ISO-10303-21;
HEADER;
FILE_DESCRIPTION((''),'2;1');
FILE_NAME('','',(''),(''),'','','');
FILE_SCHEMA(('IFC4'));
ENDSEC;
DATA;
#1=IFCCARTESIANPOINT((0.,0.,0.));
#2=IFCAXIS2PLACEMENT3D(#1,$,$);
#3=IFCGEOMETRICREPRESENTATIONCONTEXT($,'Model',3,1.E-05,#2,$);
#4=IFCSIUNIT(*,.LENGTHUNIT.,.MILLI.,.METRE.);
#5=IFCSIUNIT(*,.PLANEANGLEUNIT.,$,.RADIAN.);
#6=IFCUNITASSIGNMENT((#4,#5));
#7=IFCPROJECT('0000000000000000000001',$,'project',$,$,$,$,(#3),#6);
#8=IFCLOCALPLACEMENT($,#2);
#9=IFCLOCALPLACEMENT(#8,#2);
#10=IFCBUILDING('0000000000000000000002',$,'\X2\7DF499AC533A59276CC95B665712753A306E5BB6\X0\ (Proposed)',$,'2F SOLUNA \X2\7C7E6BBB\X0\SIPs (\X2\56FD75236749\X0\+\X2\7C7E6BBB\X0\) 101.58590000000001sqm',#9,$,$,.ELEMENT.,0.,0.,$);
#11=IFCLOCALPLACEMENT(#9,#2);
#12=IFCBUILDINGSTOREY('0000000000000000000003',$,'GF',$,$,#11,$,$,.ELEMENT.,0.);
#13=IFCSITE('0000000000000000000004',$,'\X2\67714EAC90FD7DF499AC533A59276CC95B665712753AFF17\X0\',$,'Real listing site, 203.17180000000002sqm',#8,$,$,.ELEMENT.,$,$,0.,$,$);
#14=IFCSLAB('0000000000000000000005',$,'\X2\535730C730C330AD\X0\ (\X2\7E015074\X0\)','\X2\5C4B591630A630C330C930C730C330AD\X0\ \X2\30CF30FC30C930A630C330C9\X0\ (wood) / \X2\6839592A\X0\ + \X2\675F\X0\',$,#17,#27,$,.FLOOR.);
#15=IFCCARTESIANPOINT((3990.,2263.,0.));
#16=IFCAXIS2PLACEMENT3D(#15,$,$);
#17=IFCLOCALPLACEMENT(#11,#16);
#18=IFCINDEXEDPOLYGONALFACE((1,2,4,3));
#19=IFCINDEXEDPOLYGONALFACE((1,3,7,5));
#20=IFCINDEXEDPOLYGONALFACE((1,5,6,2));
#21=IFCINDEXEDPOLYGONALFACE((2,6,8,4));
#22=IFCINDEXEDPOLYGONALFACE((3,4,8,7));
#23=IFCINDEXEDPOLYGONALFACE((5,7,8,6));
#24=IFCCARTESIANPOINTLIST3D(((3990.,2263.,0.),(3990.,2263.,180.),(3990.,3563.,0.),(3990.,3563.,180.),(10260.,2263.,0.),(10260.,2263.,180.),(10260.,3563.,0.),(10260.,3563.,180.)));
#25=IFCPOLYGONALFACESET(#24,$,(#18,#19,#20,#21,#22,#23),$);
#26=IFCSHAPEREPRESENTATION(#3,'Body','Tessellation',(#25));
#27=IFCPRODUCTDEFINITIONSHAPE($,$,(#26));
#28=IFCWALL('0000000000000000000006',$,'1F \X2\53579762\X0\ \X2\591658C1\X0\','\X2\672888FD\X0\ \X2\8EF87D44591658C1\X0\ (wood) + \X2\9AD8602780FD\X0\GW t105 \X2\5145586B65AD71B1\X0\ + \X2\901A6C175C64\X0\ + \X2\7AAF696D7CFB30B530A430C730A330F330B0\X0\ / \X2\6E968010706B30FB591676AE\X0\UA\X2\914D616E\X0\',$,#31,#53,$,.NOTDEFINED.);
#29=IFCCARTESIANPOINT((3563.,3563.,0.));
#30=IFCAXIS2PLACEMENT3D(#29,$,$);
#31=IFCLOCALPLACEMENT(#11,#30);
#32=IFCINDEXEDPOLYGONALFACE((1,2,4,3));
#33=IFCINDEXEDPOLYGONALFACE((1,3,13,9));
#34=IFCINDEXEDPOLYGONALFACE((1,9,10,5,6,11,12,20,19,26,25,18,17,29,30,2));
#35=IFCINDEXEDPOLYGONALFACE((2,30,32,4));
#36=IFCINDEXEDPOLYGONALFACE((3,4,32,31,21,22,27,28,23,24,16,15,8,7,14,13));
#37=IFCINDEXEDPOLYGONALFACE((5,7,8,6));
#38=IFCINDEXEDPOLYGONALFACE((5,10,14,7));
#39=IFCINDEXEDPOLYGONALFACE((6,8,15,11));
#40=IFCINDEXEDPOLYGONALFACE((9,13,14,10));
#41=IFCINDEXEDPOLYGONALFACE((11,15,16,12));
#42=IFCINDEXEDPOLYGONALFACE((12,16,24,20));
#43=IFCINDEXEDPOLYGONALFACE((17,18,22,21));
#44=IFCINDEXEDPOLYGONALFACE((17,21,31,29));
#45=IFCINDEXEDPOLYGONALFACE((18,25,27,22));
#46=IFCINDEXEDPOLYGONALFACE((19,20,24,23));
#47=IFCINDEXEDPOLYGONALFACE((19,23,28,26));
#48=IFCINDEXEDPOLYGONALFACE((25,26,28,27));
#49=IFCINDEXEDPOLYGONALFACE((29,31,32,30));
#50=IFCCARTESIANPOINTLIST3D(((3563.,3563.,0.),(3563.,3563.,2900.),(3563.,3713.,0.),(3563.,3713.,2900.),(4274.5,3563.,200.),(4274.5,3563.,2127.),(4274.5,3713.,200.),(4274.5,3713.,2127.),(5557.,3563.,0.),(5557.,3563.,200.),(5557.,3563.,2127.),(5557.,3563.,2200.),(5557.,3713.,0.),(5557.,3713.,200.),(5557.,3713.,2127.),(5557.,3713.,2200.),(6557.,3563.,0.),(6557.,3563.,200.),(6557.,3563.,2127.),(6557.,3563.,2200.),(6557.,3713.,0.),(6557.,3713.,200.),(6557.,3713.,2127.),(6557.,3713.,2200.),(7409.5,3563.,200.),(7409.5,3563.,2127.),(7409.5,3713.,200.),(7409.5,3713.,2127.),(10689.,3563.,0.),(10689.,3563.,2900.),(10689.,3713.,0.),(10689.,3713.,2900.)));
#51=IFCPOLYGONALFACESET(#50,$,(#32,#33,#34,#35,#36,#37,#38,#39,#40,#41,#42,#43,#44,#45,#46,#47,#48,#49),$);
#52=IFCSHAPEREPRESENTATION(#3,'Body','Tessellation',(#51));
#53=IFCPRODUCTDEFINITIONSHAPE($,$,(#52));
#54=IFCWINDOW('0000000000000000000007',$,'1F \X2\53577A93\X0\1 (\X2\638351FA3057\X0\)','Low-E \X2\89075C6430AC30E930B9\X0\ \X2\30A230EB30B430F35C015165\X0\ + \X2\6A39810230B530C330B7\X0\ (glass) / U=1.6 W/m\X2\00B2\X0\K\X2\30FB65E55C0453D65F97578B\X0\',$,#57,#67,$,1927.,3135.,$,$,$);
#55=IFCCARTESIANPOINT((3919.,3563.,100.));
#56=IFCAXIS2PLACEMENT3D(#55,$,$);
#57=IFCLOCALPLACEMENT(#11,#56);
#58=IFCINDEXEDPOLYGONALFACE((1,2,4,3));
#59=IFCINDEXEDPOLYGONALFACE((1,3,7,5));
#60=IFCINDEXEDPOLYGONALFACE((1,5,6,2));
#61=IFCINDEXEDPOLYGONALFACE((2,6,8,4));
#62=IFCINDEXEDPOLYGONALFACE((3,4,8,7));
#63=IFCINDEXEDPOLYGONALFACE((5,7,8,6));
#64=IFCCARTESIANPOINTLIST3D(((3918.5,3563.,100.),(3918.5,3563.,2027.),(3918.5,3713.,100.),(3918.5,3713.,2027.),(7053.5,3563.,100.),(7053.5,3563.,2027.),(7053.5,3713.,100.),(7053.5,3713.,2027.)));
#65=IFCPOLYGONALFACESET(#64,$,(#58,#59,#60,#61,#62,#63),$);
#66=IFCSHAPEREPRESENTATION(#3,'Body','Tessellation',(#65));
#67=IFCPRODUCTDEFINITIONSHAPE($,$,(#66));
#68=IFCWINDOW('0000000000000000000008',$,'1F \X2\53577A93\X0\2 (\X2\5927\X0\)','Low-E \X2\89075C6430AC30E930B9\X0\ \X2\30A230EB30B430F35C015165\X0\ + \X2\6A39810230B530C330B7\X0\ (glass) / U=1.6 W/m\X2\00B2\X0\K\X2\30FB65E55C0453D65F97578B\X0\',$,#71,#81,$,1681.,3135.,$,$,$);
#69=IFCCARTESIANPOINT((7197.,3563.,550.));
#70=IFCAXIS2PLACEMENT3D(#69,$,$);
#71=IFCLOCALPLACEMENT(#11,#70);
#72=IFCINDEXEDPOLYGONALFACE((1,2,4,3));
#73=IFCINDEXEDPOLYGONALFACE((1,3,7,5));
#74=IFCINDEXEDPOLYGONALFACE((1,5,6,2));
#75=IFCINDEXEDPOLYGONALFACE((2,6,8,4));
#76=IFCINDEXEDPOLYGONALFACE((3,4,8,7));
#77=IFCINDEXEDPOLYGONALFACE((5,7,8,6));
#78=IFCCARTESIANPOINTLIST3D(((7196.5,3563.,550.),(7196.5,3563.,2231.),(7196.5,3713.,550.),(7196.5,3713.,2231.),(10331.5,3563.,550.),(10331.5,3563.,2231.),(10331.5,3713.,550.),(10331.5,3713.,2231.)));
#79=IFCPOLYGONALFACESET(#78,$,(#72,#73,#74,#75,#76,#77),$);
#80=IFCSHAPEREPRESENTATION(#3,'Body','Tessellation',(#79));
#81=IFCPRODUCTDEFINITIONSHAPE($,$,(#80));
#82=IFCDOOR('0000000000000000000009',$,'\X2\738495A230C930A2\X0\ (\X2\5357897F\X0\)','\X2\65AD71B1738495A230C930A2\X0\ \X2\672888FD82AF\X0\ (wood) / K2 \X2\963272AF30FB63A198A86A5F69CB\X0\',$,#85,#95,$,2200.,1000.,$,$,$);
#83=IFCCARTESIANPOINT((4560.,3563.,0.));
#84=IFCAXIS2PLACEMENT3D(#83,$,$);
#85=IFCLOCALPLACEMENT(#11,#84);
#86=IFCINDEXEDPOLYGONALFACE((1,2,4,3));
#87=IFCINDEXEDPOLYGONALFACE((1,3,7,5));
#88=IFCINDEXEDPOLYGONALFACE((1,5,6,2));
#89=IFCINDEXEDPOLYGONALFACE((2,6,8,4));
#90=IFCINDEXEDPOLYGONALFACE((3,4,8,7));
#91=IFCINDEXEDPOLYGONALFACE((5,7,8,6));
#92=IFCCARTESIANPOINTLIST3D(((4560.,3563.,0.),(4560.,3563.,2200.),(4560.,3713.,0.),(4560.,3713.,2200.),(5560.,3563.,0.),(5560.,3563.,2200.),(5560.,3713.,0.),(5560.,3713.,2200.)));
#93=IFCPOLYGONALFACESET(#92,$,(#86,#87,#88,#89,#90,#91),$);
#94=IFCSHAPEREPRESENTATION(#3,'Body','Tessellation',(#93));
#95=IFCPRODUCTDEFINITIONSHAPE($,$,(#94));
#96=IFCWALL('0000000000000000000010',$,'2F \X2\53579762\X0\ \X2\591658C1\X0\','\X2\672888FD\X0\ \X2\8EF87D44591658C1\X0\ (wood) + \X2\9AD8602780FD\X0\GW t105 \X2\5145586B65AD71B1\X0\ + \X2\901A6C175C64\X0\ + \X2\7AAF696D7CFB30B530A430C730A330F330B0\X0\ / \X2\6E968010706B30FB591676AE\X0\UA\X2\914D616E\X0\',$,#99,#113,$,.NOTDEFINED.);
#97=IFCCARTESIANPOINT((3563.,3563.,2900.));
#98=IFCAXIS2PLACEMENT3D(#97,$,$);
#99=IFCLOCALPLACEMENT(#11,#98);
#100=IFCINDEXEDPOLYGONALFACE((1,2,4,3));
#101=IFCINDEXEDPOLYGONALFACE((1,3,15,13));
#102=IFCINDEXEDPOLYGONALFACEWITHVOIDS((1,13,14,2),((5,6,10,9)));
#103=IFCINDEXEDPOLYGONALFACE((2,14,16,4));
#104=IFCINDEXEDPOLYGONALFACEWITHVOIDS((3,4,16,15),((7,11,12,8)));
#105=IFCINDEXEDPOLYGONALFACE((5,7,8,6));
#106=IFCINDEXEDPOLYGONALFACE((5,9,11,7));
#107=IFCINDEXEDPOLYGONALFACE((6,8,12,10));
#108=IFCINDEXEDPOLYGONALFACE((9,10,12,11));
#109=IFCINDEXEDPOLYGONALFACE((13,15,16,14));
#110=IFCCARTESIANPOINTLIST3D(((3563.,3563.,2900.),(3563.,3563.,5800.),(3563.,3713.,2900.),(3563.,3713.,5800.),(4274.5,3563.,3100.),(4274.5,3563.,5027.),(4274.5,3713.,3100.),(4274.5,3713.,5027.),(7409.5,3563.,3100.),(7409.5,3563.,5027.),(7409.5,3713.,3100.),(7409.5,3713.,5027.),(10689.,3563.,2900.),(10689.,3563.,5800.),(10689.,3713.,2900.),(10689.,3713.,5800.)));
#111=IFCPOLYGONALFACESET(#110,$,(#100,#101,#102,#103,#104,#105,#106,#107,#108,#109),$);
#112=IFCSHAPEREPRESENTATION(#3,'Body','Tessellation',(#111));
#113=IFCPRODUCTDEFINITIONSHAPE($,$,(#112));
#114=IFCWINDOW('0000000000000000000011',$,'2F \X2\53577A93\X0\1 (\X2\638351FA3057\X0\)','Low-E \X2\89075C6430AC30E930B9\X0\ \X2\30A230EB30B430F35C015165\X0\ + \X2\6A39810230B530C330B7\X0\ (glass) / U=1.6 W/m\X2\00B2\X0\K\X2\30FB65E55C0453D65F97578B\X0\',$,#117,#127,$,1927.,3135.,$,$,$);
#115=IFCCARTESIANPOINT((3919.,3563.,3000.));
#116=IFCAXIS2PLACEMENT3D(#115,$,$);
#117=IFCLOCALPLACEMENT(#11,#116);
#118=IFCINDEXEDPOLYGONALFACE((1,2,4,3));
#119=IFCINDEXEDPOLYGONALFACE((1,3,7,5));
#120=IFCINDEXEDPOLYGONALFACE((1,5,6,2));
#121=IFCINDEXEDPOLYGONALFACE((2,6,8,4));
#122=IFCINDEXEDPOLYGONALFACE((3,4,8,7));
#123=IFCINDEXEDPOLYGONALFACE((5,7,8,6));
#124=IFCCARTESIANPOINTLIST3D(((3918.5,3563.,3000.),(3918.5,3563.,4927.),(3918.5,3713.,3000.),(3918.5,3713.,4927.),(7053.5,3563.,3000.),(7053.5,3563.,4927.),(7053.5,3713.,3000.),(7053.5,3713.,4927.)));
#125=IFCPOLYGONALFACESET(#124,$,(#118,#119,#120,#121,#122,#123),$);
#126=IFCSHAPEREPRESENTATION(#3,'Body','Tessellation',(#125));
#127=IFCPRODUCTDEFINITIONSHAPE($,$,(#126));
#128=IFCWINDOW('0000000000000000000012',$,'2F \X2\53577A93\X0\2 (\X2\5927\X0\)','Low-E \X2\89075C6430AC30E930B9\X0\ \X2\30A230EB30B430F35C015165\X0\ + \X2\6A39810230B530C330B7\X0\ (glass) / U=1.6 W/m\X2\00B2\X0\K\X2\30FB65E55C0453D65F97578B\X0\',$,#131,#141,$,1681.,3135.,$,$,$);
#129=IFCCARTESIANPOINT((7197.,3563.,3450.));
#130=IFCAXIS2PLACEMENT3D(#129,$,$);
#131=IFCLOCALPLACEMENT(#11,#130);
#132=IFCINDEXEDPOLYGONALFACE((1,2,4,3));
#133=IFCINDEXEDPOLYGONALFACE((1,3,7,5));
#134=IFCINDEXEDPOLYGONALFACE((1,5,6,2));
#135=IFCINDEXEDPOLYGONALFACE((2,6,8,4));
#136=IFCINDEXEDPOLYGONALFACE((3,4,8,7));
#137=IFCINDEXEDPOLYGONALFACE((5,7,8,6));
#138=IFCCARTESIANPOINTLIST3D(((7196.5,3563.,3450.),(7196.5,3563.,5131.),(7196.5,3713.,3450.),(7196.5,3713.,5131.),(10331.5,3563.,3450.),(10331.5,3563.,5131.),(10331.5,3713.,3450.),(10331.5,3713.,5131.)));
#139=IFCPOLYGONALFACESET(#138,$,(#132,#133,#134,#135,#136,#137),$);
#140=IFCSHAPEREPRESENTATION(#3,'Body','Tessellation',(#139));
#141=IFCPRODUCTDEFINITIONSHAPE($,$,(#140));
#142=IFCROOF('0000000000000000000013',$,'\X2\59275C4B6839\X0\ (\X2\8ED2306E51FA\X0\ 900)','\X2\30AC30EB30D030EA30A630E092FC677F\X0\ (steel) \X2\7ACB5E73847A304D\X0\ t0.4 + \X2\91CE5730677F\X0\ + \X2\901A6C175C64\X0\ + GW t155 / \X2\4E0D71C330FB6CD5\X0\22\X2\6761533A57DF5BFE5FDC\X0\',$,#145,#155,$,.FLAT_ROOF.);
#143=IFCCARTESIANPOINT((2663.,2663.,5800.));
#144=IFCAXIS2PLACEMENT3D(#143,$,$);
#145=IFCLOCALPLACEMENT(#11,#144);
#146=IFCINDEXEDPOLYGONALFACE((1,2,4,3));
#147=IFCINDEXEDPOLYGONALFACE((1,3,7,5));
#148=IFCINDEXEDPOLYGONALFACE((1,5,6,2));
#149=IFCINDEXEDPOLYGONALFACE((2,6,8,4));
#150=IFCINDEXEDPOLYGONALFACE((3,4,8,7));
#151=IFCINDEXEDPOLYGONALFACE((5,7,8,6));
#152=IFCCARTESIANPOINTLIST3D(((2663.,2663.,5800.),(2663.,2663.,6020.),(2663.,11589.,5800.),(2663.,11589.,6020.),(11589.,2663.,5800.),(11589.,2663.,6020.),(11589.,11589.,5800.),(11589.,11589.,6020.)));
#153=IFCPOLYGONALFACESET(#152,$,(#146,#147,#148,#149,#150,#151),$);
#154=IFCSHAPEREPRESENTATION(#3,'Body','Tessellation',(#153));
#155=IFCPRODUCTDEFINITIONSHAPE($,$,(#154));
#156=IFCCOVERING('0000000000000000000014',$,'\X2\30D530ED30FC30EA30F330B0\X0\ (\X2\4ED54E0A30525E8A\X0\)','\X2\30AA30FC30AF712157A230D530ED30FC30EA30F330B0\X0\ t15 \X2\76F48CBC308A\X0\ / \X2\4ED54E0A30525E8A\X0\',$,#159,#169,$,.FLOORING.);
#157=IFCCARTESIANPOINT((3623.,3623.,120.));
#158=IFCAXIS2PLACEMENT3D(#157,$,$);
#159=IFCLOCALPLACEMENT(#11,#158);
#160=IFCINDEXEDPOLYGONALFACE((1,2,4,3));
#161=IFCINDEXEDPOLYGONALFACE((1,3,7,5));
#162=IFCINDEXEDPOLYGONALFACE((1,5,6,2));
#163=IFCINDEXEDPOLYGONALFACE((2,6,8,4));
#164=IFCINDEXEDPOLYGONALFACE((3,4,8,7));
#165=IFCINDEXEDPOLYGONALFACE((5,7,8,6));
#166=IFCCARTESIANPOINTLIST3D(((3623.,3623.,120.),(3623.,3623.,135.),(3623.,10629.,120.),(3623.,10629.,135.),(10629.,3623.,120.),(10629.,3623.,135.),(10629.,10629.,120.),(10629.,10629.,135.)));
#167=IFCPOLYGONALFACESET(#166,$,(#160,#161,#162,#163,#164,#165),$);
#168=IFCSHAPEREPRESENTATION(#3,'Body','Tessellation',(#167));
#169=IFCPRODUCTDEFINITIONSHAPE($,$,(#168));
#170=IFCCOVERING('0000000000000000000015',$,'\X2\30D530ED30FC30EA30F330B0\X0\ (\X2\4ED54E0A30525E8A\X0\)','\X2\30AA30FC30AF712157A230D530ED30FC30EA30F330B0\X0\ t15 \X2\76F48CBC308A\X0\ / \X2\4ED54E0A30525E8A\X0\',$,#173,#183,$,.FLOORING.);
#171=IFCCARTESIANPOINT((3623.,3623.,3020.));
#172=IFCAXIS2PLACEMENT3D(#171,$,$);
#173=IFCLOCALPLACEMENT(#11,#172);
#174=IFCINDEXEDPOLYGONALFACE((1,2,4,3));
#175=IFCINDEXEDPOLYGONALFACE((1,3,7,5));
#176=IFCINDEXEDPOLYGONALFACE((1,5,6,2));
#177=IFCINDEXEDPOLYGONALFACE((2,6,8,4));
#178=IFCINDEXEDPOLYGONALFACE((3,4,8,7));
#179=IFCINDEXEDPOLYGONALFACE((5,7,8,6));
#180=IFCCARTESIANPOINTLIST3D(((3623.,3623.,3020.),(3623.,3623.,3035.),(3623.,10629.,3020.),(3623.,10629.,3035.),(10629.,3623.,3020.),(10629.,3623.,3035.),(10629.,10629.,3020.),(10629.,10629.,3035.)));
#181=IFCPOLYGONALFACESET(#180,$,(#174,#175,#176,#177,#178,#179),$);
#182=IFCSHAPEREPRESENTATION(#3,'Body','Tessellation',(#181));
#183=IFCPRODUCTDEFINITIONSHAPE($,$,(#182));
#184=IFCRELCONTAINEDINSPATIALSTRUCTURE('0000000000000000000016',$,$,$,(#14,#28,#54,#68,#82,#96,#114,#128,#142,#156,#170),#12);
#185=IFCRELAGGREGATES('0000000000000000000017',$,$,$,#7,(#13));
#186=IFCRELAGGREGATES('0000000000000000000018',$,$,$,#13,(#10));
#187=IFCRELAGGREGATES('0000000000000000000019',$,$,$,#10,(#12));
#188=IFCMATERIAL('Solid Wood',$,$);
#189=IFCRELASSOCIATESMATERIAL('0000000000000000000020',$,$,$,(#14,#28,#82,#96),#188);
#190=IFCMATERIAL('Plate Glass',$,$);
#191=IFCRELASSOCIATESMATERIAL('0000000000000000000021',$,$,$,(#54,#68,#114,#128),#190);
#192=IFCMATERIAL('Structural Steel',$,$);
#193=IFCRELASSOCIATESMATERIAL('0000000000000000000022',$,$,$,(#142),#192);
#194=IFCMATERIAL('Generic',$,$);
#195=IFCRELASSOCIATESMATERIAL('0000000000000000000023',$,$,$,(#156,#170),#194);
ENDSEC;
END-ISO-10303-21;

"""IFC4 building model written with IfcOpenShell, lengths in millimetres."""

from ifc_helpers import new_model, si_unit, frame, frame_2d, origin, place, context, project, spatial, rectangle, extrude, material, element, fill, save


model = new_model("IFC4")

# Units and contexts
model_context = context("Model", 3, precision=1e-05, world=origin())
ifc_project = project(units=[si_unit("LENGTHUNIT", "METRE", prefix="MILLI"), si_unit("PLANEANGLEUNIT", "RADIAN")], contexts=[model_context])

# Site, building, storey
site_placement = place(None, origin())
site = spatial("IfcSite", under=ifc_project, at=site_placement, Name="東京都練馬区大泉学園町７", ObjectType="Real listing site, 203.17180000000002sqm", CompositionType="ELEMENT", RefElevation=0.0)
building_placement = place(site_placement, origin())
building = spatial("IfcBuilding", under=site, at=building_placement, Name="練馬区大泉学園町の家 (Proposed)", ObjectType="2F SOLUNA 籾殻SIPs (国産杉+籾殻) 101.58590000000001sqm", CompositionType="ELEMENT", ElevationOfRefHeight=0.0, ElevationOfTerrain=0.0)
storey_placement = place(building_placement, origin())
storey = spatial("IfcBuildingStorey", under=building, at=storey_placement, Name="GF", CompositionType="ELEMENT", Elevation=0.0)

# Slab
ifc_material_1 = material(Name="Solid Wood")
slab_1_placement = place(storey_placement, frame((3990.0, 2263.0, 0.0)))
element("IfcSlab", 1, at=slab_1_placement, inside=storey, material=ifc_material_1, Name="南デッキ (縁側)", Description="屋外ウッドデッキ ハードウッド (wood) / 根太 + 束", PredefinedType="FLOOR", context=model_context, shape_type="SweptSolid", body=[
    extrude(rectangle(XDim=6270.0, YDim=1300.0, at=frame_2d((3135.0, 650.0))), frame((3990.0, 2263.0, 0.0)), (0.0, 0.0, 1.0), 180.0),
])

# Wall, openings, windows, door
wall_1_placement = place(storey_placement, frame((3563.0, 3563.0, 0.0)))
wall_1 = element("IfcWall", 2, at=wall_1_placement, inside=storey, material=ifc_material_1, Name="1F 南面 外壁", Description="木製 軸組外壁 (wood) + 高性能GW t105 充填断熱 + 通気層 + 窯業系サイディング / 準耐火・外皮UA配慮", PredefinedType="NOTDEFINED", context=model_context, shape_type="SweptSolid", body=[
    extrude(rectangle(XDim=7126.0, YDim=150.0, at=frame_2d((3563.0, 75.0))), frame((3563.0, 3563.0, 0.0)), (0.0, 0.0, 1.0), 2900.0),
])
opening_1_placement = place(storey_placement, frame((3919.0, 3563.0, 100.0)))
opening_1 = element("IfcOpeningElement", 3, at=opening_1_placement, cuts=wall_1, PredefinedType="NOTDEFINED", context=model_context, shape_type="SweptSolid", body=[
    extrude(rectangle(XDim=3135.0, YDim=150.0, at=frame_2d((1567.0, 75.0))), frame((3919.0, 3563.0, 100.0)), (0.0, 0.0, 1.0), 1927.0),
])
opening_2_placement = place(storey_placement, frame((7197.0, 3563.0, 550.0)))
opening_2 = element("IfcOpeningElement", 4, at=opening_2_placement, cuts=wall_1, PredefinedType="NOTDEFINED", context=model_context, shape_type="SweptSolid", body=[
    extrude(rectangle(XDim=3135.0, YDim=150.0, at=frame_2d((1567.0, 75.0))), frame((7197.0, 3563.0, 550.0)), (0.0, 0.0, 1.0), 1681.0),
])
opening_3_placement = place(storey_placement, frame((4560.0, 3563.0, 0.0)))
opening_3 = element("IfcOpeningElement", 5, at=opening_3_placement, cuts=wall_1, PredefinedType="NOTDEFINED", context=model_context, shape_type="SweptSolid", body=[
    extrude(rectangle(XDim=1000.0, YDim=150.0, at=frame_2d((500.0, 75.0))), frame((4560.0, 3563.0, 0.0)), (0.0, 0.0, 1.0), 2200.0),
])
ifc_material_2 = material(Name="Plate Glass")
window_1_placement = place(storey_placement, frame((3919.0, 3563.0, 100.0)))
window_1 = element("IfcWindow", 6, at=window_1_placement, inside=storey, material=ifc_material_2, Name="1F 南窓1 (掃出し)", Description="Low-E 複層ガラス アルゴン封入 + 樹脂サッシ (glass) / U=1.6 W/m²K・日射取得型", OverallHeight=1927.0, OverallWidth=3135.0, context=model_context, shape_type="SweptSolid", body=[
    extrude(rectangle(XDim=3135.0, YDim=150.0, at=frame_2d((1567.0, 75.0))), frame((3919.0, 3563.0, 100.0)), (0.0, 0.0, 1.0), 1927.0),
])
fill(opening_1, window_1)
window_2_placement = place(storey_placement, frame((7197.0, 3563.0, 550.0)))
window_2 = element("IfcWindow", 7, at=window_2_placement, inside=storey, material=ifc_material_2, Name="1F 南窓2 (大)", Description="Low-E 複層ガラス アルゴン封入 + 樹脂サッシ (glass) / U=1.6 W/m²K・日射取得型", OverallHeight=1681.0, OverallWidth=3135.0, context=model_context, shape_type="SweptSolid", body=[
    extrude(rectangle(XDim=3135.0, YDim=150.0, at=frame_2d((1567.0, 75.0))), frame((7197.0, 3563.0, 550.0)), (0.0, 0.0, 1.0), 1681.0),
])
fill(opening_2, window_2)
door_placement = place(storey_placement, frame((4560.0, 3563.0, 0.0)))
door = element("IfcDoor", 8, at=door_placement, inside=storey, material=ifc_material_1, Name="玄関ドア (南西)", Description="断熱玄関ドア 木製芯 (wood) / K2 防犯・採風機構", OverallHeight=2200.0, OverallWidth=1000.0, context=model_context, shape_type="SweptSolid", body=[
    extrude(rectangle(XDim=1000.0, YDim=150.0, at=frame_2d((500.0, 75.0))), frame((4560.0, 3563.0, 0.0)), (0.0, 0.0, 1.0), 2200.0),
])
fill(opening_3, door)

# Wall, openings, windows
wall_2_placement = place(storey_placement, frame((3563.0, 3563.0, 2900.0)))
wall_2 = element("IfcWall", 9, at=wall_2_placement, inside=storey, material=ifc_material_1, Name="2F 南面 外壁", Description="木製 軸組外壁 (wood) + 高性能GW t105 充填断熱 + 通気層 + 窯業系サイディング / 準耐火・外皮UA配慮", PredefinedType="NOTDEFINED", context=model_context, shape_type="SweptSolid", body=[
    extrude(rectangle(XDim=7126.0, YDim=150.0, at=frame_2d((3563.0, 75.0))), frame((3563.0, 3563.0, 2900.0)), (0.0, 0.0, 1.0), 2900.0),
])
opening_4_placement = place(storey_placement, frame((3919.0, 3563.0, 3000.0)))
opening_4 = element("IfcOpeningElement", 10, at=opening_4_placement, cuts=wall_2, PredefinedType="NOTDEFINED", context=model_context, shape_type="SweptSolid", body=[
    extrude(rectangle(XDim=3135.0, YDim=150.0, at=frame_2d((1567.0, 75.0))), frame((3919.0, 3563.0, 3000.0)), (0.0, 0.0, 1.0), 1927.0),
])
opening_5_placement = place(storey_placement, frame((7197.0, 3563.0, 3450.0)))
opening_5 = element("IfcOpeningElement", 11, at=opening_5_placement, cuts=wall_2, PredefinedType="NOTDEFINED", context=model_context, shape_type="SweptSolid", body=[
    extrude(rectangle(XDim=3135.0, YDim=150.0, at=frame_2d((1567.0, 75.0))), frame((7197.0, 3563.0, 3450.0)), (0.0, 0.0, 1.0), 1681.0),
])
window_3_placement = place(storey_placement, frame((3919.0, 3563.0, 3000.0)))
window_3 = element("IfcWindow", 12, at=window_3_placement, inside=storey, material=ifc_material_2, Name="2F 南窓1 (掃出し)", Description="Low-E 複層ガラス アルゴン封入 + 樹脂サッシ (glass) / U=1.6 W/m²K・日射取得型", OverallHeight=1927.0, OverallWidth=3135.0, context=model_context, shape_type="SweptSolid", body=[
    extrude(rectangle(XDim=3135.0, YDim=150.0, at=frame_2d((1567.0, 75.0))), frame((3919.0, 3563.0, 3000.0)), (0.0, 0.0, 1.0), 1927.0),
])
fill(opening_4, window_3)
window_4_placement = place(storey_placement, frame((7197.0, 3563.0, 3450.0)))
window_4 = element("IfcWindow", 13, at=window_4_placement, inside=storey, material=ifc_material_2, Name="2F 南窓2 (大)", Description="Low-E 複層ガラス アルゴン封入 + 樹脂サッシ (glass) / U=1.6 W/m²K・日射取得型", OverallHeight=1681.0, OverallWidth=3135.0, context=model_context, shape_type="SweptSolid", body=[
    extrude(rectangle(XDim=3135.0, YDim=150.0, at=frame_2d((1567.0, 75.0))), frame((7197.0, 3563.0, 3450.0)), (0.0, 0.0, 1.0), 1681.0),
])
fill(opening_5, window_4)

# Roof
ifc_material_3 = material(Name="Structural Steel")
roof_placement = place(storey_placement, frame((2663.0, 2663.0, 5800.0)))
element("IfcRoof", 14, at=roof_placement, inside=storey, material=ifc_material_3, Name="大屋根 (軒の出 900)", Description="ガルバリウム鋼板 (steel) 立平葺き t0.4 + 野地板 + 通気層 + GW t155 / 不燃・法22条区域対応", PredefinedType="FLAT_ROOF", context=model_context, shape_type="SweptSolid", body=[
    extrude(rectangle(XDim=8926.0, YDim=8926.0, at=frame_2d((4463.0, 4463.0))), frame((2663.0, 2663.0, 5800.0)), (0.0, 0.0, 1.0), 220.0),
])

# Coverings
ifc_material_4 = material(Name="Generic")
covering_1_placement = place(storey_placement, frame((3623.0, 3623.0, 120.0)))
element("IfcCovering", 15, at=covering_1_placement, inside=storey, material=ifc_material_4, Name="フローリング (仕上げ床)", Description="オーク無垢フローリング t15 直貼り / 仕上げ床", PredefinedType="FLOORING", context=model_context, shape_type="SweptSolid", body=[
    extrude(rectangle(XDim=7006.0, YDim=7006.0, at=frame_2d((3503.0, 3503.0))), frame((3623.0, 3623.0, 120.0)), (0.0, 0.0, 1.0), 15.0),
])
covering_2_placement = place(storey_placement, frame((3623.0, 3623.0, 3020.0)))
element("IfcCovering", 16, at=covering_2_placement, inside=storey, material=ifc_material_4, Name="フローリング (仕上げ床)", Description="オーク無垢フローリング t15 直貼り / 仕上げ床", PredefinedType="FLOORING", context=model_context, shape_type="SweptSolid", body=[
    extrude(rectangle(XDim=7006.0, YDim=7006.0, at=frame_2d((3503.0, 3503.0))), frame((3623.0, 3623.0, 3020.0)), (0.0, 0.0, 1.0), 15.0),
])

save(model, "model.ifc")
